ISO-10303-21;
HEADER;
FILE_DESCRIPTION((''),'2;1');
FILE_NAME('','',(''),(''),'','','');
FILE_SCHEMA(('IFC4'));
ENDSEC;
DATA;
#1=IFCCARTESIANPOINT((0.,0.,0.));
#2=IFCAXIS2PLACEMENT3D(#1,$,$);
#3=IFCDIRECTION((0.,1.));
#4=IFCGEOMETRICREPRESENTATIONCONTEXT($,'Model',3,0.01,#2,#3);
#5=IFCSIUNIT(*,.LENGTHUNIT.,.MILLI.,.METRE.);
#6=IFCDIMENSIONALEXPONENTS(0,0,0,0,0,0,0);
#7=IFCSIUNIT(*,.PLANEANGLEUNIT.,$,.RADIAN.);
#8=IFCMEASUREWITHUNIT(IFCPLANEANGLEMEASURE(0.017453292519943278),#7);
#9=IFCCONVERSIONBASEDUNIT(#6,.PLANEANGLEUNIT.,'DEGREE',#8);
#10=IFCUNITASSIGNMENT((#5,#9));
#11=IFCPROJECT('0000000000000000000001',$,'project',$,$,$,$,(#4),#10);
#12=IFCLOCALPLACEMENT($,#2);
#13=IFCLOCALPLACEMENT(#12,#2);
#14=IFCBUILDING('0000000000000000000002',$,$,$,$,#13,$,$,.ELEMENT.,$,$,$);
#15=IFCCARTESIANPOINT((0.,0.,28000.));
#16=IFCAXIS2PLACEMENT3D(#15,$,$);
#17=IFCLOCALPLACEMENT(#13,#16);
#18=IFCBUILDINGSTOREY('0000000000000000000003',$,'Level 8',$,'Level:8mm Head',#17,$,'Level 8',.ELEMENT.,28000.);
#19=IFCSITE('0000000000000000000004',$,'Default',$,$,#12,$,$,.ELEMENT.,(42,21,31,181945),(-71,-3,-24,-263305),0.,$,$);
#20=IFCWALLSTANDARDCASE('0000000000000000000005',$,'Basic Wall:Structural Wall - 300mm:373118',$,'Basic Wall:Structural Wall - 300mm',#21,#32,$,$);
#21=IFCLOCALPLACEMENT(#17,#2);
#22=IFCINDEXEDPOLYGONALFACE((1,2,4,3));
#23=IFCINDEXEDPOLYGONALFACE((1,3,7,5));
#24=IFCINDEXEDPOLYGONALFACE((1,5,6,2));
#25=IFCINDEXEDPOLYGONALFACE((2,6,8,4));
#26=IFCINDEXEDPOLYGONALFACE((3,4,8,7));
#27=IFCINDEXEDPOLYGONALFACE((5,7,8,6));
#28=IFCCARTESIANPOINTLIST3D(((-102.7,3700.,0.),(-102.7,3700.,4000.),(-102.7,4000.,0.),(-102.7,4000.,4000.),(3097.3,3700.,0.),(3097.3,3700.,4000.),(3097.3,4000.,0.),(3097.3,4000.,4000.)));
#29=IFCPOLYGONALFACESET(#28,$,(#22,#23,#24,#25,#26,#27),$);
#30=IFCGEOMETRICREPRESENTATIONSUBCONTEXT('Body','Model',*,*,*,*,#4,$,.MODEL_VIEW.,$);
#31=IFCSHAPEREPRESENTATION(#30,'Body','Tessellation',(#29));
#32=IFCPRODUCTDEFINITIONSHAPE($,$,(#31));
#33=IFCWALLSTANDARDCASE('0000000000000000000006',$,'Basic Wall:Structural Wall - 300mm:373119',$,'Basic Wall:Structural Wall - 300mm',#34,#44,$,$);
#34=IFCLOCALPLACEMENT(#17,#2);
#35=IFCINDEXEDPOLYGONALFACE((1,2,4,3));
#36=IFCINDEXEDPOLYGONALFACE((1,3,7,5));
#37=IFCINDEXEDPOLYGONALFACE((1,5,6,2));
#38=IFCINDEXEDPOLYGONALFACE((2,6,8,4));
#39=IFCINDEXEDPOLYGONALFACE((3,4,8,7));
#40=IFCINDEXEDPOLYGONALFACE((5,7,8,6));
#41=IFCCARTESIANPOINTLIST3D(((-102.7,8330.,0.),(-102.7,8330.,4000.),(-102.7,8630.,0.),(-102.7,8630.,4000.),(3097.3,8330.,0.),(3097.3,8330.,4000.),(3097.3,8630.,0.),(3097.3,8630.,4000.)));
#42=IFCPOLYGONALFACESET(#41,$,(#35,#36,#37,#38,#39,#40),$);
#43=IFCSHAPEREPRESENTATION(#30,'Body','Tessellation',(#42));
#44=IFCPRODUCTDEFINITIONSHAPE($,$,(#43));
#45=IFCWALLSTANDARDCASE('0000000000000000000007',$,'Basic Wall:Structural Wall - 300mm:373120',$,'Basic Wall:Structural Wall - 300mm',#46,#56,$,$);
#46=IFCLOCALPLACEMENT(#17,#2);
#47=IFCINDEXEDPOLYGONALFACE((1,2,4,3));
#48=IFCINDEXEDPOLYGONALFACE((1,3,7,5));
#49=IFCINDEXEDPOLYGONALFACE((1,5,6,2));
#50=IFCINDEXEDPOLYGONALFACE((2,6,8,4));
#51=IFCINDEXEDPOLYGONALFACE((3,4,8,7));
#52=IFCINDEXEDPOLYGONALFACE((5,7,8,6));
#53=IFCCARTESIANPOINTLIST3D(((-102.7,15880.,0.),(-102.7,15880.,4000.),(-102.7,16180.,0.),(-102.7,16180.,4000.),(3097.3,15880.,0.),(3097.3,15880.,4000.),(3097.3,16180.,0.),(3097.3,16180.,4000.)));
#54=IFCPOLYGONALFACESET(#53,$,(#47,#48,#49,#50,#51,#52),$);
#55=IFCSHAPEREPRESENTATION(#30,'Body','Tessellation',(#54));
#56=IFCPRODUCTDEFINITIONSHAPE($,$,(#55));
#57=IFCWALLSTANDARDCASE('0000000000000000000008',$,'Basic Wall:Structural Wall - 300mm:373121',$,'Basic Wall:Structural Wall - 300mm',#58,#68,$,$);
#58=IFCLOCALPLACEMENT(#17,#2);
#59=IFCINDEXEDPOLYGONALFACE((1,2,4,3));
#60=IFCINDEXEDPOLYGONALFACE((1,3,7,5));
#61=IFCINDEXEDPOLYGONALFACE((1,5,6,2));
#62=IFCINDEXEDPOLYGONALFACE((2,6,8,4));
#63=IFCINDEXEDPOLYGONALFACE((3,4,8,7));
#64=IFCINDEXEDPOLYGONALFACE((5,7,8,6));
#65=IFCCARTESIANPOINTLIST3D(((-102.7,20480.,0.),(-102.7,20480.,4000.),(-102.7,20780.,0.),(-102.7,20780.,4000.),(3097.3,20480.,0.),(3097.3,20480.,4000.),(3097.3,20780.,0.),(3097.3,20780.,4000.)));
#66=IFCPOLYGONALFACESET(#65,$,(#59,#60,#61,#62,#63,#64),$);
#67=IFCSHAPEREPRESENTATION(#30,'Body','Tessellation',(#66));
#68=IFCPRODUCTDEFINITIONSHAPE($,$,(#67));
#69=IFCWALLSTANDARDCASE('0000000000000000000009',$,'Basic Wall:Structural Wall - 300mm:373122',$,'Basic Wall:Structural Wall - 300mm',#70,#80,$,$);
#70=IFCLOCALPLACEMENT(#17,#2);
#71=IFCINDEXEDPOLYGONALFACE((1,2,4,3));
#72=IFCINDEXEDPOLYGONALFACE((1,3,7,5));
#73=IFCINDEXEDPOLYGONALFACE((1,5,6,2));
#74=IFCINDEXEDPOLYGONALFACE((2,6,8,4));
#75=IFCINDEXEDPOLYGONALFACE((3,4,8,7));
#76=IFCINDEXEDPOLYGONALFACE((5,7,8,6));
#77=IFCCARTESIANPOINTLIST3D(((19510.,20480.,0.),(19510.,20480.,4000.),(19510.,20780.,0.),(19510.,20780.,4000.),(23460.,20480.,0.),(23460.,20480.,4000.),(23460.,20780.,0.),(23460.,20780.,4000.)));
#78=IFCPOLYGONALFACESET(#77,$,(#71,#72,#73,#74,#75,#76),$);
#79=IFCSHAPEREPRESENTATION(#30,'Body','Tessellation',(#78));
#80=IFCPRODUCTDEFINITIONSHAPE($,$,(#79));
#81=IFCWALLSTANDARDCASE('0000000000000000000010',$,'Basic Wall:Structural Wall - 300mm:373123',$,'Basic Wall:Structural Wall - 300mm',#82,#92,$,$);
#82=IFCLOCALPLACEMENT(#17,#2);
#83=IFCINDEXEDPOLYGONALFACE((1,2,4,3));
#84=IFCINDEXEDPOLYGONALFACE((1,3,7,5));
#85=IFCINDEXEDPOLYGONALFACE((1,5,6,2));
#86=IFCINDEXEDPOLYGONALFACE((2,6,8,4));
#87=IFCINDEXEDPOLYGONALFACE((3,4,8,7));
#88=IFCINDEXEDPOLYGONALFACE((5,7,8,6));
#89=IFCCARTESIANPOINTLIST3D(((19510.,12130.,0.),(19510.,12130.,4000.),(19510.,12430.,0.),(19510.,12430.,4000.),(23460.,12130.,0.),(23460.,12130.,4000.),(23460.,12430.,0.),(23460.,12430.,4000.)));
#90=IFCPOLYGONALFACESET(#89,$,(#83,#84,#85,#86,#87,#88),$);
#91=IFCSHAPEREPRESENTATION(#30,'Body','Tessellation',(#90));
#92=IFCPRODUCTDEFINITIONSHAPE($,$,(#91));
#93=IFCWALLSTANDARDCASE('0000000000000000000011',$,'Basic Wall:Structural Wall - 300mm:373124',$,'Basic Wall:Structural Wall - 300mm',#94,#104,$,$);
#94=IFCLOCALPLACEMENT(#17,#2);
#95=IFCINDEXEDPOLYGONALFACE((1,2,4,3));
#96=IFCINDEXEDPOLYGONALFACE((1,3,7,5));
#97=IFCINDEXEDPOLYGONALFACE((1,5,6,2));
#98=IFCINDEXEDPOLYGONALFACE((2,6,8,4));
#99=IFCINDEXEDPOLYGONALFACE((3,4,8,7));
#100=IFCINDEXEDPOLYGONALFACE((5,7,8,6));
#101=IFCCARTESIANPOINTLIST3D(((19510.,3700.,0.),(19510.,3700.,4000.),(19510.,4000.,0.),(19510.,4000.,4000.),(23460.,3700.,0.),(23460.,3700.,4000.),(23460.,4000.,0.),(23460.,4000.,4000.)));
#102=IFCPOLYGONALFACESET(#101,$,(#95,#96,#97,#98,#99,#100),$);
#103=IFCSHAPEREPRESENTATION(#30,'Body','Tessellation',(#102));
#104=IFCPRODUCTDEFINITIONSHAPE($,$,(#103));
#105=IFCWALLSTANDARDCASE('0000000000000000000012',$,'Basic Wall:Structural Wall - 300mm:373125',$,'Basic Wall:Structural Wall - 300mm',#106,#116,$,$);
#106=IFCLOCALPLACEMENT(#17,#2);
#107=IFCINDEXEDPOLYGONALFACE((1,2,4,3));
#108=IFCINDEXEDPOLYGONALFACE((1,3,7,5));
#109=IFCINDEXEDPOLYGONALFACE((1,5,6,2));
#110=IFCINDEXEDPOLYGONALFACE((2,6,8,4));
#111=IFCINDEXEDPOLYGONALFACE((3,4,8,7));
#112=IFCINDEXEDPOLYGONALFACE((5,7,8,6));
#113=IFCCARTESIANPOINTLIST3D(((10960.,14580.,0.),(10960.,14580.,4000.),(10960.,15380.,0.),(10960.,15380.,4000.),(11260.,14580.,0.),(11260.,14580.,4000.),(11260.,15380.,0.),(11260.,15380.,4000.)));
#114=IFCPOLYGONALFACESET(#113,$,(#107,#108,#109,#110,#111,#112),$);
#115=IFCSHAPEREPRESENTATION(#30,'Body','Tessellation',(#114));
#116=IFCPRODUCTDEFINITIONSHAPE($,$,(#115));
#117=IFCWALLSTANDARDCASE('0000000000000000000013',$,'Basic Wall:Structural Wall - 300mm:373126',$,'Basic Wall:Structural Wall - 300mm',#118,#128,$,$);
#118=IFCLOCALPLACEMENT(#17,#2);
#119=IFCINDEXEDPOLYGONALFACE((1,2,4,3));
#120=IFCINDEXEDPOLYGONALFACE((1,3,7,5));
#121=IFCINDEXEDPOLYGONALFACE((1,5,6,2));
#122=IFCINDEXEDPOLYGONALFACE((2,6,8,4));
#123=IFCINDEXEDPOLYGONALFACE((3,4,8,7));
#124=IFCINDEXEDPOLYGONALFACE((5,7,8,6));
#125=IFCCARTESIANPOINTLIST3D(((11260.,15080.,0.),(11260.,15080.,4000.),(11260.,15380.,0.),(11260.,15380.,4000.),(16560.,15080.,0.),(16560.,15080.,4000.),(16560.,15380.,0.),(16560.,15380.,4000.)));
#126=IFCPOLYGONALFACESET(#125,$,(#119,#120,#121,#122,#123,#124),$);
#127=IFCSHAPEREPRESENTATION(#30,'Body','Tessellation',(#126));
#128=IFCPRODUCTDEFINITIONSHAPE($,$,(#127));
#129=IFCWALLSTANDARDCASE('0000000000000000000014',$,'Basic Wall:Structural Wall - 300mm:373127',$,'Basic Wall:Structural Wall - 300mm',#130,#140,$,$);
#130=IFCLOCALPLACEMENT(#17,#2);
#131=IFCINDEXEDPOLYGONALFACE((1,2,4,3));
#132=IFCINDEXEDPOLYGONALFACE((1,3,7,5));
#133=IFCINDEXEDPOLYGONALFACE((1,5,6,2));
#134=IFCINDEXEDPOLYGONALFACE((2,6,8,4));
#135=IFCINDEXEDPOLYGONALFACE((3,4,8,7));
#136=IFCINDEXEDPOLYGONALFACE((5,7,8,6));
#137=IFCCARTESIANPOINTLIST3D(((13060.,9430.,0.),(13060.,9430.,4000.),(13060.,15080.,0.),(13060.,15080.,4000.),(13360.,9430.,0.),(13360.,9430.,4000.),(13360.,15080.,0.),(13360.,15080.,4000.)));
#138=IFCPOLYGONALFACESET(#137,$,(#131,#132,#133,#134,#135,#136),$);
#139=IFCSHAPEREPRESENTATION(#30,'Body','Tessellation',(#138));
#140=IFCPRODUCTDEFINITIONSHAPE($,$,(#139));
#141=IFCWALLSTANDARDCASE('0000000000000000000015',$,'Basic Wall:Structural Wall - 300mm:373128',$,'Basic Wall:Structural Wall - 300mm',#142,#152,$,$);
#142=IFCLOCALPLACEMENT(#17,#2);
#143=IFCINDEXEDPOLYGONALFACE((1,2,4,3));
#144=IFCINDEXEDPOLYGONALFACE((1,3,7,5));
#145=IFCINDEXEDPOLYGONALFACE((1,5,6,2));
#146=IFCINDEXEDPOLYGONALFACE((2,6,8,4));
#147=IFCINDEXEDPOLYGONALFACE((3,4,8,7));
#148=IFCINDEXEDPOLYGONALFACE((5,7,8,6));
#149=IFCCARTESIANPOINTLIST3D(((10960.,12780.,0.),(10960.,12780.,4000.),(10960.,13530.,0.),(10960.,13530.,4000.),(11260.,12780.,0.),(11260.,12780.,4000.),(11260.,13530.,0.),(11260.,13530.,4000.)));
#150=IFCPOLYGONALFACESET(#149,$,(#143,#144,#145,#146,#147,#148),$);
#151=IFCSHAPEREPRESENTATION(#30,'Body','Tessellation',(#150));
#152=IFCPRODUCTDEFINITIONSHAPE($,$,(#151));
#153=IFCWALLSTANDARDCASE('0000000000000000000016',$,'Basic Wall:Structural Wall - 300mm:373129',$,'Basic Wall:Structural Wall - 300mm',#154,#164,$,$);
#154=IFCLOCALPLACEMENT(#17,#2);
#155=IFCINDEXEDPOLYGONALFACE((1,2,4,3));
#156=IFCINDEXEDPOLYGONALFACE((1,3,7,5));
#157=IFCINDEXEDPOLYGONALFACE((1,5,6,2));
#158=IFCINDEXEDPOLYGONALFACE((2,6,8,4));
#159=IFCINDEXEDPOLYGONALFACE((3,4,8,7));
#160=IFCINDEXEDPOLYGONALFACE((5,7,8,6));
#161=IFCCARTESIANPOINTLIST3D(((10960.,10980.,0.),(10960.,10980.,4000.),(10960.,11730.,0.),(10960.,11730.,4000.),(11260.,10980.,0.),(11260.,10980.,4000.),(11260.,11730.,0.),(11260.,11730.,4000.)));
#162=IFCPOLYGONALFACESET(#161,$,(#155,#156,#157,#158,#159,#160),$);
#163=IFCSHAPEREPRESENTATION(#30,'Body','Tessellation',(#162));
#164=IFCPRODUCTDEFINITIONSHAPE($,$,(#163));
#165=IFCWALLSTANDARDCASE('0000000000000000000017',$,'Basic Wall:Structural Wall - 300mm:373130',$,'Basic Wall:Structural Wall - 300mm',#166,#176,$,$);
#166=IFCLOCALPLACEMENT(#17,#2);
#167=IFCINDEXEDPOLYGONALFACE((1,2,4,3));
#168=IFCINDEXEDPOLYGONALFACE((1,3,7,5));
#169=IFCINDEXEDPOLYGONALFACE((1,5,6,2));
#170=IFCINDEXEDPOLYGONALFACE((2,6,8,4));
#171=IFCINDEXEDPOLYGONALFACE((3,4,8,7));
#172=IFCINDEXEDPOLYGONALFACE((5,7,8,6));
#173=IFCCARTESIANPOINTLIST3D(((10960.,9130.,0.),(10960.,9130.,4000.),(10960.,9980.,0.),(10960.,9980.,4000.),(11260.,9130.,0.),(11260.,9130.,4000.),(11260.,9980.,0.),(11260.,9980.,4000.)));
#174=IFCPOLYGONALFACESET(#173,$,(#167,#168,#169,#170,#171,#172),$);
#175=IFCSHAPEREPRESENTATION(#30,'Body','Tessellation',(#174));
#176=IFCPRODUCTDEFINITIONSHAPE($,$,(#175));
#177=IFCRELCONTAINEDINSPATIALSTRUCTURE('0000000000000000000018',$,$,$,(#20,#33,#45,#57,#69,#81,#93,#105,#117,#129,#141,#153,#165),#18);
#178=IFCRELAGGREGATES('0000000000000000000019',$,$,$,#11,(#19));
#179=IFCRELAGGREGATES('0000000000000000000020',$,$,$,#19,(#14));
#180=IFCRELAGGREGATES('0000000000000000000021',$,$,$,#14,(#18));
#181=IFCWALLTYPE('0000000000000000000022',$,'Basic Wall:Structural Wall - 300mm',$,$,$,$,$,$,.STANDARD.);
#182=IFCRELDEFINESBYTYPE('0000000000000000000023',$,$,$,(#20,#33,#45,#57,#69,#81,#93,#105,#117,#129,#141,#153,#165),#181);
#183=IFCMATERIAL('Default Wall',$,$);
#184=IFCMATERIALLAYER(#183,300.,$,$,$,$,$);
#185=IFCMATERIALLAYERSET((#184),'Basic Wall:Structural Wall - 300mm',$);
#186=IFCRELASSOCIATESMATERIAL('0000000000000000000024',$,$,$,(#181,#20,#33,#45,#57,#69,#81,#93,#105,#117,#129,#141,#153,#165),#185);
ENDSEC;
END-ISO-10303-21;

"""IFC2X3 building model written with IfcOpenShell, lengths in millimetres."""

from ifc_helpers import new_model, entity, si_unit, converted_unit, direction, frame, frame_2d, origin, place, context, subcontext, project, spatial, rectangle, extrude, material, layer, layer_set, layer_usage, type_object, element, save


model = new_model("IFC2X3")

# Units and contexts
model_context = context("Model", 3, precision=0.01, world=origin(), true_north=direction((0.0, 1.0)))
body_context = subcontext(model_context, "Body", "Model", "MODEL_VIEW")
ifc_project = project(units=[si_unit("LENGTHUNIT", "METRE", prefix="MILLI"), converted_unit("PLANEANGLEUNIT", "DEGREE", entity("IfcPlaneAngleMeasure", 0.017453292519943278), si_unit("PLANEANGLEUNIT", "RADIAN"), dimensions=[0, 0, 0, 0, 0, 0, 0])], contexts=[model_context])

# Site, building, storey
site_placement = place(None, origin())
site = spatial("IfcSite", under=ifc_project, at=site_placement, Name="Default", CompositionType="ELEMENT", RefLatitude=(42, 21, 31, 181945), RefLongitude=(-71, -3, -24, -263305), RefElevation=0.0)
building_placement = place(site_placement, origin())
building = spatial("IfcBuilding", under=site, at=building_placement, CompositionType="ELEMENT")
storey_placement = place(building_placement, frame((0.0, 0.0, 28000.0)))
storey = spatial("IfcBuildingStorey", under=building, at=storey_placement, Name="Level 8", ObjectType="Level:8mm Head", LongName="Level 8", CompositionType="ELEMENT", Elevation=28000.0)

# Walls
ifc_material_1 = material(Name="Default Wall")
ifc_layer_1 = layer(ifc_material_1, 300.0)
ifc_layer_set_1 = layer_set([ifc_layer_1], Name="Basic Wall:Structural Wall - 300mm")
ifc_layer_usage_1 = layer_usage(ifc_layer_set_1, "AXIS2", "NEGATIVE", 150.0)
wall_type = type_object("IfcWallType", Name="Basic Wall:Structural Wall - 300mm", PredefinedType="STANDARD", material=ifc_layer_set_1)
wall_1_placement = place(storey_placement, frame((3097.3, 3850.0, 0.0), z_axis=(0.0, 0.0, 1.0), x_axis=(-1.0, 0.0, 0.0)))
element("IfcWallStandardCase", 1, at=wall_1_placement, inside=storey, type_object=wall_type, material=ifc_layer_usage_1, Name="Basic Wall:Structural Wall - 300mm:373118", ObjectType="Basic Wall:Structural Wall - 300mm", context=body_context, shape_type="SweptSolid", body=[
    extrude(rectangle(XDim=3200.0, YDim=300.0, at=frame_2d((1600.0, 0.0), x_axis=(-1.0, 0.0))), origin(), (0.0, 0.0, 1.0), 4000.0),
])
ifc_layer_usage_2 = layer_usage(ifc_layer_set_1, "AXIS2", "NEGATIVE", 150.0)
wall_2_placement = place(storey_placement, frame((-102.7, 8480.0, 0.0)))
element("IfcWallStandardCase", 2, at=wall_2_placement, inside=storey, type_object=wall_type, material=ifc_layer_usage_2, Name="Basic Wall:Structural Wall - 300mm:373119", ObjectType="Basic Wall:Structural Wall - 300mm", context=body_context, shape_type="SweptSolid", body=[
    extrude(rectangle(XDim=3200.0, YDim=300.0, at=frame_2d((1600.0, 0.0), x_axis=(-1.0, 0.0))), origin(), (0.0, 0.0, 1.0), 4000.0),
])
ifc_layer_usage_3 = layer_usage(ifc_layer_set_1, "AXIS2", "NEGATIVE", 150.0)
wall_3_placement = place(storey_placement, frame((-102.7, 16030.0, 0.0)))
element("IfcWallStandardCase", 3, at=wall_3_placement, inside=storey, type_object=wall_type, material=ifc_layer_usage_3, Name="Basic Wall:Structural Wall - 300mm:373120", ObjectType="Basic Wall:Structural Wall - 300mm", context=body_context, shape_type="SweptSolid", body=[
    extrude(rectangle(XDim=3200.0, YDim=300.0, at=frame_2d((1600.0, 0.0), x_axis=(-1.0, 0.0))), origin(), (0.0, 0.0, 1.0), 4000.0),
])
ifc_layer_usage_4 = layer_usage(ifc_layer_set_1, "AXIS2", "NEGATIVE", 150.0)
wall_4_placement = place(storey_placement, frame((-102.7, 20630.0, 0.0)))
element("IfcWallStandardCase", 4, at=wall_4_placement, inside=storey, type_object=wall_type, material=ifc_layer_usage_4, Name="Basic Wall:Structural Wall - 300mm:373121", ObjectType="Basic Wall:Structural Wall - 300mm", context=body_context, shape_type="SweptSolid", body=[
    extrude(rectangle(XDim=3200.0, YDim=300.0, at=frame_2d((1600.0, 0.0), x_axis=(-1.0, 0.0))), origin(), (0.0, 0.0, 1.0), 4000.0),
])
ifc_layer_usage_5 = layer_usage(ifc_layer_set_1, "AXIS2", "NEGATIVE", 150.0)
wall_5_placement = place(storey_placement, frame((19510.0, 20630.0, 0.0)))
element("IfcWallStandardCase", 5, at=wall_5_placement, inside=storey, type_object=wall_type, material=ifc_layer_usage_5, Name="Basic Wall:Structural Wall - 300mm:373122", ObjectType="Basic Wall:Structural Wall - 300mm", context=body_context, shape_type="SweptSolid", body=[
    extrude(rectangle(XDim=3950.0, YDim=300.0, at=frame_2d((1975.0, 0.0), x_axis=(-1.0, 0.0))), origin(), (0.0, 0.0, 1.0), 4000.0),
])
ifc_layer_usage_6 = layer_usage(ifc_layer_set_1, "AXIS2", "NEGATIVE", 150.0)
wall_6_placement = place(storey_placement, frame((19510.0, 12280.0, 0.0)))
element("IfcWallStandardCase", 6, at=wall_6_placement, inside=storey, type_object=wall_type, material=ifc_layer_usage_6, Name="Basic Wall:Structural Wall - 300mm:373123", ObjectType="Basic Wall:Structural Wall - 300mm", context=body_context, shape_type="SweptSolid", body=[
    extrude(rectangle(XDim=3950.0, YDim=300.0, at=frame_2d((1975.0, 0.0), x_axis=(-1.0, 0.0))), origin(), (0.0, 0.0, 1.0), 4000.0),
])
ifc_layer_usage_7 = layer_usage(ifc_layer_set_1, "AXIS2", "NEGATIVE", 150.0)
wall_7_placement = place(storey_placement, frame((19510.0, 3850.0, 0.0)))
element("IfcWallStandardCase", 7, at=wall_7_placement, inside=storey, type_object=wall_type, material=ifc_layer_usage_7, Name="Basic Wall:Structural Wall - 300mm:373124", ObjectType="Basic Wall:Structural Wall - 300mm", context=body_context, shape_type="SweptSolid", body=[
    extrude(rectangle(XDim=3950.0, YDim=300.0, at=frame_2d((1975.0, 0.0), x_axis=(-1.0, 0.0))), origin(), (0.0, 0.0, 1.0), 4000.0),
])
ifc_layer_usage_8 = layer_usage(ifc_layer_set_1, "AXIS2", "NEGATIVE", 150.0)
wall_8_placement = place(storey_placement, frame((11110.0, 14580.0, 0.0), z_axis=(0.0, 0.0, 1.0), x_axis=(0.0, 1.0, 0.0)))
element("IfcWallStandardCase", 8, at=wall_8_placement, inside=storey, type_object=wall_type, material=ifc_layer_usage_8, Name="Basic Wall:Structural Wall - 300mm:373125", ObjectType="Basic Wall:Structural Wall - 300mm", context=body_context, shape_type="SweptSolid", body=[
    extrude(rectangle(XDim=800.0, YDim=300.0, at=frame_2d((400.0, 0.0), x_axis=(-1.0, 0.0))), origin(), (0.0, 0.0, 1.0), 4000.0),
])
ifc_layer_usage_9 = layer_usage(ifc_layer_set_1, "AXIS2", "NEGATIVE", 150.0)
wall_9_placement = place(storey_placement, frame((11260.0, 15230.0, 0.0)))
element("IfcWallStandardCase", 9, at=wall_9_placement, inside=storey, type_object=wall_type, material=ifc_layer_usage_9, Name="Basic Wall:Structural Wall - 300mm:373126", ObjectType="Basic Wall:Structural Wall - 300mm", context=body_context, shape_type="SweptSolid", body=[
    extrude(rectangle(XDim=5300.0, YDim=300.0, at=frame_2d((2650.0, 0.0), x_axis=(-1.0, 0.0))), origin(), (0.0, 0.0, 1.0), 4000.0),
])
ifc_layer_usage_10 = layer_usage(ifc_layer_set_1, "AXIS2", "NEGATIVE", 150.0)
wall_10_placement = place(storey_placement, frame((13210.0, 15080.0, 0.0), z_axis=(0.0, 0.0, 1.0), x_axis=(0.0, -1.0, 0.0)))
element("IfcWallStandardCase", 10, at=wall_10_placement, inside=storey, type_object=wall_type, material=ifc_layer_usage_10, Name="Basic Wall:Structural Wall - 300mm:373127", ObjectType="Basic Wall:Structural Wall - 300mm", context=body_context, shape_type="SweptSolid", body=[
    extrude(rectangle(XDim=5650.0, YDim=300.0, at=frame_2d((2825.0, 0.0), x_axis=(-1.0, 0.0))), origin(), (0.0, 0.0, 1.0), 4000.0),
])
ifc_layer_usage_11 = layer_usage(ifc_layer_set_1, "AXIS2", "NEGATIVE", 150.0)
wall_11_placement = place(storey_placement, frame((11110.0, 13530.0, 0.0), z_axis=(0.0, 0.0, 1.0), x_axis=(0.0, -1.0, 0.0)))
element("IfcWallStandardCase", 11, at=wall_11_placement, inside=storey, type_object=wall_type, material=ifc_layer_usage_11, Name="Basic Wall:Structural Wall - 300mm:373128", ObjectType="Basic Wall:Structural Wall - 300mm", context=body_context, shape_type="SweptSolid", body=[
    extrude(rectangle(XDim=750.0, YDim=300.0, at=frame_2d((375.0, 0.0), x_axis=(-1.0, 0.0))), origin(), (0.0, 0.0, 1.0), 4000.0),
])
ifc_layer_usage_12 = layer_usage(ifc_layer_set_1, "AXIS2", "NEGATIVE", 150.0)
wall_12_placement = place(storey_placement, frame((11110.0, 11730.0, 0.0), z_axis=(0.0, 0.0, 1.0), x_axis=(0.0, -1.0, 0.0)))
element("IfcWallStandardCase", 12, at=wall_12_placement, inside=storey, type_object=wall_type, material=ifc_layer_usage_12, Name="Basic Wall:Structural Wall - 300mm:373129", ObjectType="Basic Wall:Structural Wall - 300mm", context=body_context, shape_type="SweptSolid", body=[
    extrude(rectangle(XDim=750.0, YDim=300.0, at=frame_2d((375.0, 0.0), x_axis=(-1.0, 0.0))), origin(), (0.0, 0.0, 1.0), 4000.0),
])
ifc_layer_usage_13 = layer_usage(ifc_layer_set_1, "AXIS2", "NEGATIVE", 150.0)
wall_13_placement = place(storey_placement, frame((11110.0, 9980.0, 0.0), z_axis=(0.0, 0.0, 1.0), x_axis=(0.0, -1.0, 0.0)))
element("IfcWallStandardCase", 13, at=wall_13_placement, inside=storey, type_object=wall_type, material=ifc_layer_usage_13, Name="Basic Wall:Structural Wall - 300mm:373130", ObjectType="Basic Wall:Structural Wall - 300mm", context=body_context, shape_type="SweptSolid", body=[
    extrude(rectangle(XDim=850.0, YDim=300.0, at=frame_2d((425.0, 0.0), x_axis=(-1.0, 0.0))), origin(), (0.0, 0.0, 1.0), 4000.0),
])

save(model, "model.ifc")
